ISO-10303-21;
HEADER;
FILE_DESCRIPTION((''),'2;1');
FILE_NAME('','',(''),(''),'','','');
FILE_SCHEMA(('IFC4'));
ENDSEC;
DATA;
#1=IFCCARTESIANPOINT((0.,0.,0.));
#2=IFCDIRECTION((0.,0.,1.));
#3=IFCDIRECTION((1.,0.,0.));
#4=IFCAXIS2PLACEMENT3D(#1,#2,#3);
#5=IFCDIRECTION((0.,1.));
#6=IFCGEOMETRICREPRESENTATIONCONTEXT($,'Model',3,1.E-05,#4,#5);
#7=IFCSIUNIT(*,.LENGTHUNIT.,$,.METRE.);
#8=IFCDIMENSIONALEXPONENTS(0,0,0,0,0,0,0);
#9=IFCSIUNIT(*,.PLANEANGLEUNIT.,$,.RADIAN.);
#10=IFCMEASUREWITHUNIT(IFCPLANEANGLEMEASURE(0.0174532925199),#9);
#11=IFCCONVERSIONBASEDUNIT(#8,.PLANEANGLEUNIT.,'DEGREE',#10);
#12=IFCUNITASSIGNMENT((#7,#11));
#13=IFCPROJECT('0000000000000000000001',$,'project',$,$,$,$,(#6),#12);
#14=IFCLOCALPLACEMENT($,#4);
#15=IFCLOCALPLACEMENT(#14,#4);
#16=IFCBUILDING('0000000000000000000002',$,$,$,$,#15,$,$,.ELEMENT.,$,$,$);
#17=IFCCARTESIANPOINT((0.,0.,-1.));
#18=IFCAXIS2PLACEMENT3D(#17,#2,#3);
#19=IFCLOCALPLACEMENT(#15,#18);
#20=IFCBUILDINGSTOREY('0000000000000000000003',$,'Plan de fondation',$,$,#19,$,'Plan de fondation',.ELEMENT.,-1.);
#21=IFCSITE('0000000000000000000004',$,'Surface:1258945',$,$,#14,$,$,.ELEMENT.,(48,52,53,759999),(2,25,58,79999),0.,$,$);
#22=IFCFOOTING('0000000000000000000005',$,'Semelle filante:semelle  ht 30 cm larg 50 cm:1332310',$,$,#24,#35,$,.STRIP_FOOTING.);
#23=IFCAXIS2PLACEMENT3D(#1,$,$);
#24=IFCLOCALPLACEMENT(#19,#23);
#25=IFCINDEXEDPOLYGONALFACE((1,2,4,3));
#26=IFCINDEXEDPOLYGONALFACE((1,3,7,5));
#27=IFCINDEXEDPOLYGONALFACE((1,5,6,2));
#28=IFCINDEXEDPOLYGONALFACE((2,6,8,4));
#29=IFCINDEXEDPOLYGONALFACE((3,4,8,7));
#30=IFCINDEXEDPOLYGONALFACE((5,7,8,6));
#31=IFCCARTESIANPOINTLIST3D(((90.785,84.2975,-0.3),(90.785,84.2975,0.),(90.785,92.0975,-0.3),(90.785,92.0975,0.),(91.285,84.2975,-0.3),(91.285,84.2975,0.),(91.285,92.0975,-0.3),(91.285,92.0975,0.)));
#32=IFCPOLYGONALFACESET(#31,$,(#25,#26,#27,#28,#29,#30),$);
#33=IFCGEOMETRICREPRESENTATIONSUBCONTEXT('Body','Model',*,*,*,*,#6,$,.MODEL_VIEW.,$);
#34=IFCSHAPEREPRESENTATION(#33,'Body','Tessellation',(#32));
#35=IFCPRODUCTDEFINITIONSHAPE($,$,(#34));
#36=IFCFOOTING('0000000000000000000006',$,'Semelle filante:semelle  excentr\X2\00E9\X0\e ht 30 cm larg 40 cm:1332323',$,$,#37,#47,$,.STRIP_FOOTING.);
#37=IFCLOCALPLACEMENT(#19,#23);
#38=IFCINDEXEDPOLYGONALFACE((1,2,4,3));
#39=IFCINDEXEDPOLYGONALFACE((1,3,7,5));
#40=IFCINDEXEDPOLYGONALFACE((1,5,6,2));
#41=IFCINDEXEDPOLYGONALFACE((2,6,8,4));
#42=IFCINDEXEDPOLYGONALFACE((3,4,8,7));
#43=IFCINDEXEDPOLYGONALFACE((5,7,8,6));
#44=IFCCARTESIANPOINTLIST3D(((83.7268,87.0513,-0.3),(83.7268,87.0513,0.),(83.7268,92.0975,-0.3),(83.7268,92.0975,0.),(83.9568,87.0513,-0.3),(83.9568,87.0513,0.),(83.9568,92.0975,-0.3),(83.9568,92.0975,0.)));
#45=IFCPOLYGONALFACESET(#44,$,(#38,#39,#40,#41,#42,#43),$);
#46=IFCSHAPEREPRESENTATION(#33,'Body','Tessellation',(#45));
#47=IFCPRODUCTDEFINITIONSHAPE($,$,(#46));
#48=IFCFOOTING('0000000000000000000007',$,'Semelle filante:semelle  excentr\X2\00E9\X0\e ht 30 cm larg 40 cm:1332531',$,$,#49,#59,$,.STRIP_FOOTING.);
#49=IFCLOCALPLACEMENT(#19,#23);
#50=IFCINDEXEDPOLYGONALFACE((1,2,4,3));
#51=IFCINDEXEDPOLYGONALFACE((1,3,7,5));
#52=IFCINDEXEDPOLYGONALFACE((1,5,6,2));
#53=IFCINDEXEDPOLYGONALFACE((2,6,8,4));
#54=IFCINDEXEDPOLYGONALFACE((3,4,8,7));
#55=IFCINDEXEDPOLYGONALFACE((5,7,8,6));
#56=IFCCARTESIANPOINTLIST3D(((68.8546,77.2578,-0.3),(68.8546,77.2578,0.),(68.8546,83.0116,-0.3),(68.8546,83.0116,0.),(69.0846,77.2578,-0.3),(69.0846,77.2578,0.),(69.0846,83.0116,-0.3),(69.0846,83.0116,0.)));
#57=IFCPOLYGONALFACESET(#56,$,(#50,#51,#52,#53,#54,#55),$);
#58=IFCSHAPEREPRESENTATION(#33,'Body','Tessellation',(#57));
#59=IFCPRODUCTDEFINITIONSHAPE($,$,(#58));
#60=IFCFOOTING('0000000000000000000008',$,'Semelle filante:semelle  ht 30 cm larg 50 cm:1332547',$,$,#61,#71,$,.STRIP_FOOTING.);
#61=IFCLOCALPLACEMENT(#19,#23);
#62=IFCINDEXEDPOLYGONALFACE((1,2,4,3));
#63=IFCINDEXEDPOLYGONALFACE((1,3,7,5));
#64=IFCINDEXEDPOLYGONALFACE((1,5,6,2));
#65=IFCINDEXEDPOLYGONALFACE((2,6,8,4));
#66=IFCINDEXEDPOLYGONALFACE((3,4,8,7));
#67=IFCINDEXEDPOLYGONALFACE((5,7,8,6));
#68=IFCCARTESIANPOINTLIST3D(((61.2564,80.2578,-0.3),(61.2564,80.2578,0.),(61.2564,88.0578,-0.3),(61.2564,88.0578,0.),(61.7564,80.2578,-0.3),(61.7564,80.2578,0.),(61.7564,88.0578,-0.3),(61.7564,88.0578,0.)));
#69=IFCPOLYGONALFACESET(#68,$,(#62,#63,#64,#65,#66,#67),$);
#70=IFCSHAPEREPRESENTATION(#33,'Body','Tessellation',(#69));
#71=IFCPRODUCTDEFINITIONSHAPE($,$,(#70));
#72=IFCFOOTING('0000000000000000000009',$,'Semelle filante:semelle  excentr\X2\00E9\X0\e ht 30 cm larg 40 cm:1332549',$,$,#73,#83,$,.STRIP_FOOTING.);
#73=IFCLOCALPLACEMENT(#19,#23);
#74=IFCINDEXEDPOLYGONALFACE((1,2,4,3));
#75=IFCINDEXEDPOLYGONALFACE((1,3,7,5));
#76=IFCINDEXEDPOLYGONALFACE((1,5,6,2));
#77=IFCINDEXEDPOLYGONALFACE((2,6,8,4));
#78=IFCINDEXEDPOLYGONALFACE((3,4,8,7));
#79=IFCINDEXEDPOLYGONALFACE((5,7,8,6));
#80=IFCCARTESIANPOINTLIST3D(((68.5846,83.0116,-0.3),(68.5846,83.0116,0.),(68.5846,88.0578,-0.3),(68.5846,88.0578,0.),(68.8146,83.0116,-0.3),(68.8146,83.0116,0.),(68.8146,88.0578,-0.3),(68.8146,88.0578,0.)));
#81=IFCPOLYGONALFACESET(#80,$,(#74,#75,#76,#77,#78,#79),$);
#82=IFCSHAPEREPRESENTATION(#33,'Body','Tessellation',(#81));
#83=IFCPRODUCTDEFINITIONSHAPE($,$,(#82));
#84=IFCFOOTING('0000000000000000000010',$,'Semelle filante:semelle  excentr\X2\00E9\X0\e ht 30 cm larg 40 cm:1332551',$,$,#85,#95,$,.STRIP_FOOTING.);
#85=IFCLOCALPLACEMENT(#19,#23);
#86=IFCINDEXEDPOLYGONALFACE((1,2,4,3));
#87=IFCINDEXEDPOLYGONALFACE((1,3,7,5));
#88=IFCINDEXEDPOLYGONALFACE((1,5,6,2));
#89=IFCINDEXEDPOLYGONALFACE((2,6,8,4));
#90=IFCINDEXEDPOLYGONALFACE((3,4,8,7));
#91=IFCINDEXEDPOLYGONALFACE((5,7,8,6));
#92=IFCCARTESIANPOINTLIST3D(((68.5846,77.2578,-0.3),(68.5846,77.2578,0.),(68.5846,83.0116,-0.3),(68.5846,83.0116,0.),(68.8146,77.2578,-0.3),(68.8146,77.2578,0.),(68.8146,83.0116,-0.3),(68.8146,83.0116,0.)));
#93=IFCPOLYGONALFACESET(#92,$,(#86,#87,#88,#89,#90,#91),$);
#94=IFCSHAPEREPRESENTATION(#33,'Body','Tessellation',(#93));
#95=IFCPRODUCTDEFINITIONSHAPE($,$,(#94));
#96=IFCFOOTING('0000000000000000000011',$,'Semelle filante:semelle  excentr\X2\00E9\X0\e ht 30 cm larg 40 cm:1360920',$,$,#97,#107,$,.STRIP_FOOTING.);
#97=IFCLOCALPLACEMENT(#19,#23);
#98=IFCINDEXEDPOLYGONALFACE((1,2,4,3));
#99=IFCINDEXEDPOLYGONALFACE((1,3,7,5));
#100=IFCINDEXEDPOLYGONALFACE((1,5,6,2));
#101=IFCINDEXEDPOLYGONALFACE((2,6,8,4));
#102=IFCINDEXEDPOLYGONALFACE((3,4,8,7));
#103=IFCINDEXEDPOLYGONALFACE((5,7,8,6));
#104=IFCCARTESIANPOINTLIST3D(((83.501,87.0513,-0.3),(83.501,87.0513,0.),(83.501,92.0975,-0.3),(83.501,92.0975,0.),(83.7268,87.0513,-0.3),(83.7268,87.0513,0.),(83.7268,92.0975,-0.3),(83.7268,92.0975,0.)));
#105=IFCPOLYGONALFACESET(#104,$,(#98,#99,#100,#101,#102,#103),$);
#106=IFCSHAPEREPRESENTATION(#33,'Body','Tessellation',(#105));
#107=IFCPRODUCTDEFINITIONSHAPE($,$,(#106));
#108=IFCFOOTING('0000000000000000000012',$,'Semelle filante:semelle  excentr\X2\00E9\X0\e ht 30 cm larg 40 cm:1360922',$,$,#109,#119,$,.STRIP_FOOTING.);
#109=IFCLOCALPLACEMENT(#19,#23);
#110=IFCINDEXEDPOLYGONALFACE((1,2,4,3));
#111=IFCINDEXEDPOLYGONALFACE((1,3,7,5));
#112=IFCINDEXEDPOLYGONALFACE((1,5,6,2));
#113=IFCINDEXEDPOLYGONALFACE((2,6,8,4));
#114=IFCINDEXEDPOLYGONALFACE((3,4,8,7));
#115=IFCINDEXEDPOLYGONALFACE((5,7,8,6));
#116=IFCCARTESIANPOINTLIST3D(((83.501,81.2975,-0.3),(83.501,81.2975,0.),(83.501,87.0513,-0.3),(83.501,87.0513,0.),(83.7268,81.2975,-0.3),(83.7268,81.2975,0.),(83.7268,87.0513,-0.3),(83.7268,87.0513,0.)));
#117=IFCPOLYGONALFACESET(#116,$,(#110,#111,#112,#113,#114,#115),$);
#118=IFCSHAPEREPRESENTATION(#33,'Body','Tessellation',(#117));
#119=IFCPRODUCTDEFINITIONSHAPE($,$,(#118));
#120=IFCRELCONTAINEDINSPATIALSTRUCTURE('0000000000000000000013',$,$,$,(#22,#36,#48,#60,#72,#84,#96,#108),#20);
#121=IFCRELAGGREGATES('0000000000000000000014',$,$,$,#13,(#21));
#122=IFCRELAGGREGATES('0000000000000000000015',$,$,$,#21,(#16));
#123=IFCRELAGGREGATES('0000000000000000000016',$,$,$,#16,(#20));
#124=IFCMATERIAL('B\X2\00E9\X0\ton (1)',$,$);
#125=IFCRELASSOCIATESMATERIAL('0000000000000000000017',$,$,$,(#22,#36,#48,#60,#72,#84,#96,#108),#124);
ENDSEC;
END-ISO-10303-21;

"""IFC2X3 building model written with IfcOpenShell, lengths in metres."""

from ifc_helpers import new_model, entity, si_unit, converted_unit, direction, frame, origin_with_axes, origin_2d_with_axis, place, context, subcontext, project, spatial, rectangle, extrude, material, element, save


model = new_model("IFC2X3")

# Units and contexts
model_context = context("Model", 3, precision=1e-05, world=origin_with_axes(), true_north=direction((0.0, 1.0)))
body_context = subcontext(model_context, "Body", "Model", "MODEL_VIEW")
ifc_project = project(units=[si_unit("LENGTHUNIT", "METRE"), converted_unit("PLANEANGLEUNIT", "DEGREE", entity("IfcPlaneAngleMeasure", 0.0174532925199), si_unit("PLANEANGLEUNIT", "RADIAN"), dimensions=[0, 0, 0, 0, 0, 0, 0])], contexts=[model_context])

# Site, building, storey
site_placement = place(None, origin_with_axes())
site = spatial("IfcSite", under=ifc_project, at=site_placement, Name="Surface:1258945", CompositionType="ELEMENT", RefLatitude=(48, 52, 53, 759999), RefLongitude=(2, 25, 58, 79999), RefElevation=0.0)
building_placement = place(site_placement, origin_with_axes())
building = spatial("IfcBuilding", under=site, at=building_placement, CompositionType="ELEMENT")
storey_placement = place(building_placement, frame((0.0, 0.0, -1.0), z_axis=(0.0, 0.0, 1.0), x_axis=(1.0, 0.0, 0.0)))
storey = spatial("IfcBuildingStorey", under=building, at=storey_placement, Name="Plan de fondation", LongName="Plan de fondation", CompositionType="ELEMENT", Elevation=-1.0)

# Footings
ifc_material = material(Name="Béton (1)")
footing_1_placement = place(storey_placement, origin_with_axes())
element("IfcFooting", 1, at=footing_1_placement, inside=storey, material=ifc_material, Name="Semelle filante:semelle  ht 30 cm larg 50 cm:1332310", PredefinedType="STRIP_FOOTING", context=body_context, shape_type="SweptSolid", body=[
    extrude(rectangle(XDim=7.8, YDim=0.5, at=origin_2d_with_axis()), frame((91.035, 88.1975, -0.3), z_axis=(0.0, 0.0, 1.0), x_axis=(0.0, -1.0, 0.0)), (0.0, 0.0, 1.0), 0.3),
])
footing_2_placement = place(storey_placement, origin_with_axes())
element("IfcFooting", 2, at=footing_2_placement, inside=storey, material=ifc_material, Name="Semelle filante:semelle  excentrée ht 30 cm larg 40 cm:1332323", PredefinedType="STRIP_FOOTING", context=body_context, shape_type="SweptSolid", body=[
    extrude(rectangle(XDim=5.0462, YDim=0.23, at=origin_2d_with_axis()), frame((83.8418, 89.5744, -0.3), z_axis=(0.0, 0.0, 1.0), x_axis=(0.0, 1.0, 0.0)), (0.0, 0.0, 1.0), 0.3),
])
footing_3_placement = place(storey_placement, origin_with_axes())
element("IfcFooting", 3, at=footing_3_placement, inside=storey, material=ifc_material, Name="Semelle filante:semelle  excentrée ht 30 cm larg 40 cm:1332531", PredefinedType="STRIP_FOOTING", context=body_context, shape_type="SweptSolid", body=[
    extrude(rectangle(XDim=5.7538, YDim=0.23, at=origin_2d_with_axis()), frame((68.9696, 80.1347, -0.3), z_axis=(0.0, 0.0, 1.0), x_axis=(0.0, -1.0, 0.0)), (0.0, 0.0, 1.0), 0.3),
])
footing_4_placement = place(storey_placement, origin_with_axes())
element("IfcFooting", 4, at=footing_4_placement, inside=storey, material=ifc_material, Name="Semelle filante:semelle  ht 30 cm larg 50 cm:1332547", PredefinedType="STRIP_FOOTING", context=body_context, shape_type="SweptSolid", body=[
    extrude(rectangle(XDim=7.8, YDim=0.5, at=origin_2d_with_axis()), frame((61.5064, 84.1578, -0.3), z_axis=(0.0, 0.0, 1.0), x_axis=(0.0, -1.0, 0.0)), (0.0, 0.0, 1.0), 0.3),
])
footing_5_placement = place(storey_placement, origin_with_axes())
element("IfcFooting", 5, at=footing_5_placement, inside=storey, material=ifc_material, Name="Semelle filante:semelle  excentrée ht 30 cm larg 40 cm:1332549", PredefinedType="STRIP_FOOTING", context=body_context, shape_type="SweptSolid", body=[
    extrude(rectangle(XDim=5.0462, YDim=0.23, at=origin_2d_with_axis()), frame((68.6996, 85.5347, -0.3), z_axis=(0.0, 0.0, 1.0), x_axis=(0.0, 1.0, 0.0)), (0.0, 0.0, 1.0), 0.3),
])
footing_6_placement = place(storey_placement, origin_with_axes())
element("IfcFooting", 6, at=footing_6_placement, inside=storey, material=ifc_material, Name="Semelle filante:semelle  excentrée ht 30 cm larg 40 cm:1332551", PredefinedType="STRIP_FOOTING", context=body_context, shape_type="SweptSolid", body=[
    extrude(rectangle(XDim=5.7538, YDim=0.23, at=origin_2d_with_axis()), frame((68.6996, 80.1347, -0.3), z_axis=(0.0, 0.0, 1.0), x_axis=(0.0, -1.0, 0.0)), (0.0, 0.0, 1.0), 0.3),
])
footing_7_placement = place(storey_placement, origin_with_axes())
element("IfcFooting", 7, at=footing_7_placement, inside=storey, material=ifc_material, Name="Semelle filante:semelle  excentrée ht 30 cm larg 40 cm:1360920", PredefinedType="STRIP_FOOTING", context=body_context, shape_type="SweptSolid", body=[
    extrude(rectangle(XDim=0.2258, YDim=5.0462, at=origin_2d_with_axis()), frame((83.6139, 89.5744, -0.3), z_axis=(0.0, 0.0, 1.0), x_axis=(1.0, 0.0, 0.0)), (0.0, 0.0, 1.0), 0.3),
])
footing_8_placement = place(storey_placement, origin_with_axes())
element("IfcFooting", 8, at=footing_8_placement, inside=storey, material=ifc_material, Name="Semelle filante:semelle  excentrée ht 30 cm larg 40 cm:1360922", PredefinedType="STRIP_FOOTING", context=body_context, shape_type="SweptSolid", body=[
    extrude(rectangle(XDim=5.7538, YDim=0.2258, at=origin_2d_with_axis()), frame((83.6139, 84.1744, -0.3), z_axis=(0.0, 0.0, 1.0), x_axis=(0.0, 1.0, 0.0)), (0.0, 0.0, 1.0), 0.3),
])

save(model, "model.ifc")
